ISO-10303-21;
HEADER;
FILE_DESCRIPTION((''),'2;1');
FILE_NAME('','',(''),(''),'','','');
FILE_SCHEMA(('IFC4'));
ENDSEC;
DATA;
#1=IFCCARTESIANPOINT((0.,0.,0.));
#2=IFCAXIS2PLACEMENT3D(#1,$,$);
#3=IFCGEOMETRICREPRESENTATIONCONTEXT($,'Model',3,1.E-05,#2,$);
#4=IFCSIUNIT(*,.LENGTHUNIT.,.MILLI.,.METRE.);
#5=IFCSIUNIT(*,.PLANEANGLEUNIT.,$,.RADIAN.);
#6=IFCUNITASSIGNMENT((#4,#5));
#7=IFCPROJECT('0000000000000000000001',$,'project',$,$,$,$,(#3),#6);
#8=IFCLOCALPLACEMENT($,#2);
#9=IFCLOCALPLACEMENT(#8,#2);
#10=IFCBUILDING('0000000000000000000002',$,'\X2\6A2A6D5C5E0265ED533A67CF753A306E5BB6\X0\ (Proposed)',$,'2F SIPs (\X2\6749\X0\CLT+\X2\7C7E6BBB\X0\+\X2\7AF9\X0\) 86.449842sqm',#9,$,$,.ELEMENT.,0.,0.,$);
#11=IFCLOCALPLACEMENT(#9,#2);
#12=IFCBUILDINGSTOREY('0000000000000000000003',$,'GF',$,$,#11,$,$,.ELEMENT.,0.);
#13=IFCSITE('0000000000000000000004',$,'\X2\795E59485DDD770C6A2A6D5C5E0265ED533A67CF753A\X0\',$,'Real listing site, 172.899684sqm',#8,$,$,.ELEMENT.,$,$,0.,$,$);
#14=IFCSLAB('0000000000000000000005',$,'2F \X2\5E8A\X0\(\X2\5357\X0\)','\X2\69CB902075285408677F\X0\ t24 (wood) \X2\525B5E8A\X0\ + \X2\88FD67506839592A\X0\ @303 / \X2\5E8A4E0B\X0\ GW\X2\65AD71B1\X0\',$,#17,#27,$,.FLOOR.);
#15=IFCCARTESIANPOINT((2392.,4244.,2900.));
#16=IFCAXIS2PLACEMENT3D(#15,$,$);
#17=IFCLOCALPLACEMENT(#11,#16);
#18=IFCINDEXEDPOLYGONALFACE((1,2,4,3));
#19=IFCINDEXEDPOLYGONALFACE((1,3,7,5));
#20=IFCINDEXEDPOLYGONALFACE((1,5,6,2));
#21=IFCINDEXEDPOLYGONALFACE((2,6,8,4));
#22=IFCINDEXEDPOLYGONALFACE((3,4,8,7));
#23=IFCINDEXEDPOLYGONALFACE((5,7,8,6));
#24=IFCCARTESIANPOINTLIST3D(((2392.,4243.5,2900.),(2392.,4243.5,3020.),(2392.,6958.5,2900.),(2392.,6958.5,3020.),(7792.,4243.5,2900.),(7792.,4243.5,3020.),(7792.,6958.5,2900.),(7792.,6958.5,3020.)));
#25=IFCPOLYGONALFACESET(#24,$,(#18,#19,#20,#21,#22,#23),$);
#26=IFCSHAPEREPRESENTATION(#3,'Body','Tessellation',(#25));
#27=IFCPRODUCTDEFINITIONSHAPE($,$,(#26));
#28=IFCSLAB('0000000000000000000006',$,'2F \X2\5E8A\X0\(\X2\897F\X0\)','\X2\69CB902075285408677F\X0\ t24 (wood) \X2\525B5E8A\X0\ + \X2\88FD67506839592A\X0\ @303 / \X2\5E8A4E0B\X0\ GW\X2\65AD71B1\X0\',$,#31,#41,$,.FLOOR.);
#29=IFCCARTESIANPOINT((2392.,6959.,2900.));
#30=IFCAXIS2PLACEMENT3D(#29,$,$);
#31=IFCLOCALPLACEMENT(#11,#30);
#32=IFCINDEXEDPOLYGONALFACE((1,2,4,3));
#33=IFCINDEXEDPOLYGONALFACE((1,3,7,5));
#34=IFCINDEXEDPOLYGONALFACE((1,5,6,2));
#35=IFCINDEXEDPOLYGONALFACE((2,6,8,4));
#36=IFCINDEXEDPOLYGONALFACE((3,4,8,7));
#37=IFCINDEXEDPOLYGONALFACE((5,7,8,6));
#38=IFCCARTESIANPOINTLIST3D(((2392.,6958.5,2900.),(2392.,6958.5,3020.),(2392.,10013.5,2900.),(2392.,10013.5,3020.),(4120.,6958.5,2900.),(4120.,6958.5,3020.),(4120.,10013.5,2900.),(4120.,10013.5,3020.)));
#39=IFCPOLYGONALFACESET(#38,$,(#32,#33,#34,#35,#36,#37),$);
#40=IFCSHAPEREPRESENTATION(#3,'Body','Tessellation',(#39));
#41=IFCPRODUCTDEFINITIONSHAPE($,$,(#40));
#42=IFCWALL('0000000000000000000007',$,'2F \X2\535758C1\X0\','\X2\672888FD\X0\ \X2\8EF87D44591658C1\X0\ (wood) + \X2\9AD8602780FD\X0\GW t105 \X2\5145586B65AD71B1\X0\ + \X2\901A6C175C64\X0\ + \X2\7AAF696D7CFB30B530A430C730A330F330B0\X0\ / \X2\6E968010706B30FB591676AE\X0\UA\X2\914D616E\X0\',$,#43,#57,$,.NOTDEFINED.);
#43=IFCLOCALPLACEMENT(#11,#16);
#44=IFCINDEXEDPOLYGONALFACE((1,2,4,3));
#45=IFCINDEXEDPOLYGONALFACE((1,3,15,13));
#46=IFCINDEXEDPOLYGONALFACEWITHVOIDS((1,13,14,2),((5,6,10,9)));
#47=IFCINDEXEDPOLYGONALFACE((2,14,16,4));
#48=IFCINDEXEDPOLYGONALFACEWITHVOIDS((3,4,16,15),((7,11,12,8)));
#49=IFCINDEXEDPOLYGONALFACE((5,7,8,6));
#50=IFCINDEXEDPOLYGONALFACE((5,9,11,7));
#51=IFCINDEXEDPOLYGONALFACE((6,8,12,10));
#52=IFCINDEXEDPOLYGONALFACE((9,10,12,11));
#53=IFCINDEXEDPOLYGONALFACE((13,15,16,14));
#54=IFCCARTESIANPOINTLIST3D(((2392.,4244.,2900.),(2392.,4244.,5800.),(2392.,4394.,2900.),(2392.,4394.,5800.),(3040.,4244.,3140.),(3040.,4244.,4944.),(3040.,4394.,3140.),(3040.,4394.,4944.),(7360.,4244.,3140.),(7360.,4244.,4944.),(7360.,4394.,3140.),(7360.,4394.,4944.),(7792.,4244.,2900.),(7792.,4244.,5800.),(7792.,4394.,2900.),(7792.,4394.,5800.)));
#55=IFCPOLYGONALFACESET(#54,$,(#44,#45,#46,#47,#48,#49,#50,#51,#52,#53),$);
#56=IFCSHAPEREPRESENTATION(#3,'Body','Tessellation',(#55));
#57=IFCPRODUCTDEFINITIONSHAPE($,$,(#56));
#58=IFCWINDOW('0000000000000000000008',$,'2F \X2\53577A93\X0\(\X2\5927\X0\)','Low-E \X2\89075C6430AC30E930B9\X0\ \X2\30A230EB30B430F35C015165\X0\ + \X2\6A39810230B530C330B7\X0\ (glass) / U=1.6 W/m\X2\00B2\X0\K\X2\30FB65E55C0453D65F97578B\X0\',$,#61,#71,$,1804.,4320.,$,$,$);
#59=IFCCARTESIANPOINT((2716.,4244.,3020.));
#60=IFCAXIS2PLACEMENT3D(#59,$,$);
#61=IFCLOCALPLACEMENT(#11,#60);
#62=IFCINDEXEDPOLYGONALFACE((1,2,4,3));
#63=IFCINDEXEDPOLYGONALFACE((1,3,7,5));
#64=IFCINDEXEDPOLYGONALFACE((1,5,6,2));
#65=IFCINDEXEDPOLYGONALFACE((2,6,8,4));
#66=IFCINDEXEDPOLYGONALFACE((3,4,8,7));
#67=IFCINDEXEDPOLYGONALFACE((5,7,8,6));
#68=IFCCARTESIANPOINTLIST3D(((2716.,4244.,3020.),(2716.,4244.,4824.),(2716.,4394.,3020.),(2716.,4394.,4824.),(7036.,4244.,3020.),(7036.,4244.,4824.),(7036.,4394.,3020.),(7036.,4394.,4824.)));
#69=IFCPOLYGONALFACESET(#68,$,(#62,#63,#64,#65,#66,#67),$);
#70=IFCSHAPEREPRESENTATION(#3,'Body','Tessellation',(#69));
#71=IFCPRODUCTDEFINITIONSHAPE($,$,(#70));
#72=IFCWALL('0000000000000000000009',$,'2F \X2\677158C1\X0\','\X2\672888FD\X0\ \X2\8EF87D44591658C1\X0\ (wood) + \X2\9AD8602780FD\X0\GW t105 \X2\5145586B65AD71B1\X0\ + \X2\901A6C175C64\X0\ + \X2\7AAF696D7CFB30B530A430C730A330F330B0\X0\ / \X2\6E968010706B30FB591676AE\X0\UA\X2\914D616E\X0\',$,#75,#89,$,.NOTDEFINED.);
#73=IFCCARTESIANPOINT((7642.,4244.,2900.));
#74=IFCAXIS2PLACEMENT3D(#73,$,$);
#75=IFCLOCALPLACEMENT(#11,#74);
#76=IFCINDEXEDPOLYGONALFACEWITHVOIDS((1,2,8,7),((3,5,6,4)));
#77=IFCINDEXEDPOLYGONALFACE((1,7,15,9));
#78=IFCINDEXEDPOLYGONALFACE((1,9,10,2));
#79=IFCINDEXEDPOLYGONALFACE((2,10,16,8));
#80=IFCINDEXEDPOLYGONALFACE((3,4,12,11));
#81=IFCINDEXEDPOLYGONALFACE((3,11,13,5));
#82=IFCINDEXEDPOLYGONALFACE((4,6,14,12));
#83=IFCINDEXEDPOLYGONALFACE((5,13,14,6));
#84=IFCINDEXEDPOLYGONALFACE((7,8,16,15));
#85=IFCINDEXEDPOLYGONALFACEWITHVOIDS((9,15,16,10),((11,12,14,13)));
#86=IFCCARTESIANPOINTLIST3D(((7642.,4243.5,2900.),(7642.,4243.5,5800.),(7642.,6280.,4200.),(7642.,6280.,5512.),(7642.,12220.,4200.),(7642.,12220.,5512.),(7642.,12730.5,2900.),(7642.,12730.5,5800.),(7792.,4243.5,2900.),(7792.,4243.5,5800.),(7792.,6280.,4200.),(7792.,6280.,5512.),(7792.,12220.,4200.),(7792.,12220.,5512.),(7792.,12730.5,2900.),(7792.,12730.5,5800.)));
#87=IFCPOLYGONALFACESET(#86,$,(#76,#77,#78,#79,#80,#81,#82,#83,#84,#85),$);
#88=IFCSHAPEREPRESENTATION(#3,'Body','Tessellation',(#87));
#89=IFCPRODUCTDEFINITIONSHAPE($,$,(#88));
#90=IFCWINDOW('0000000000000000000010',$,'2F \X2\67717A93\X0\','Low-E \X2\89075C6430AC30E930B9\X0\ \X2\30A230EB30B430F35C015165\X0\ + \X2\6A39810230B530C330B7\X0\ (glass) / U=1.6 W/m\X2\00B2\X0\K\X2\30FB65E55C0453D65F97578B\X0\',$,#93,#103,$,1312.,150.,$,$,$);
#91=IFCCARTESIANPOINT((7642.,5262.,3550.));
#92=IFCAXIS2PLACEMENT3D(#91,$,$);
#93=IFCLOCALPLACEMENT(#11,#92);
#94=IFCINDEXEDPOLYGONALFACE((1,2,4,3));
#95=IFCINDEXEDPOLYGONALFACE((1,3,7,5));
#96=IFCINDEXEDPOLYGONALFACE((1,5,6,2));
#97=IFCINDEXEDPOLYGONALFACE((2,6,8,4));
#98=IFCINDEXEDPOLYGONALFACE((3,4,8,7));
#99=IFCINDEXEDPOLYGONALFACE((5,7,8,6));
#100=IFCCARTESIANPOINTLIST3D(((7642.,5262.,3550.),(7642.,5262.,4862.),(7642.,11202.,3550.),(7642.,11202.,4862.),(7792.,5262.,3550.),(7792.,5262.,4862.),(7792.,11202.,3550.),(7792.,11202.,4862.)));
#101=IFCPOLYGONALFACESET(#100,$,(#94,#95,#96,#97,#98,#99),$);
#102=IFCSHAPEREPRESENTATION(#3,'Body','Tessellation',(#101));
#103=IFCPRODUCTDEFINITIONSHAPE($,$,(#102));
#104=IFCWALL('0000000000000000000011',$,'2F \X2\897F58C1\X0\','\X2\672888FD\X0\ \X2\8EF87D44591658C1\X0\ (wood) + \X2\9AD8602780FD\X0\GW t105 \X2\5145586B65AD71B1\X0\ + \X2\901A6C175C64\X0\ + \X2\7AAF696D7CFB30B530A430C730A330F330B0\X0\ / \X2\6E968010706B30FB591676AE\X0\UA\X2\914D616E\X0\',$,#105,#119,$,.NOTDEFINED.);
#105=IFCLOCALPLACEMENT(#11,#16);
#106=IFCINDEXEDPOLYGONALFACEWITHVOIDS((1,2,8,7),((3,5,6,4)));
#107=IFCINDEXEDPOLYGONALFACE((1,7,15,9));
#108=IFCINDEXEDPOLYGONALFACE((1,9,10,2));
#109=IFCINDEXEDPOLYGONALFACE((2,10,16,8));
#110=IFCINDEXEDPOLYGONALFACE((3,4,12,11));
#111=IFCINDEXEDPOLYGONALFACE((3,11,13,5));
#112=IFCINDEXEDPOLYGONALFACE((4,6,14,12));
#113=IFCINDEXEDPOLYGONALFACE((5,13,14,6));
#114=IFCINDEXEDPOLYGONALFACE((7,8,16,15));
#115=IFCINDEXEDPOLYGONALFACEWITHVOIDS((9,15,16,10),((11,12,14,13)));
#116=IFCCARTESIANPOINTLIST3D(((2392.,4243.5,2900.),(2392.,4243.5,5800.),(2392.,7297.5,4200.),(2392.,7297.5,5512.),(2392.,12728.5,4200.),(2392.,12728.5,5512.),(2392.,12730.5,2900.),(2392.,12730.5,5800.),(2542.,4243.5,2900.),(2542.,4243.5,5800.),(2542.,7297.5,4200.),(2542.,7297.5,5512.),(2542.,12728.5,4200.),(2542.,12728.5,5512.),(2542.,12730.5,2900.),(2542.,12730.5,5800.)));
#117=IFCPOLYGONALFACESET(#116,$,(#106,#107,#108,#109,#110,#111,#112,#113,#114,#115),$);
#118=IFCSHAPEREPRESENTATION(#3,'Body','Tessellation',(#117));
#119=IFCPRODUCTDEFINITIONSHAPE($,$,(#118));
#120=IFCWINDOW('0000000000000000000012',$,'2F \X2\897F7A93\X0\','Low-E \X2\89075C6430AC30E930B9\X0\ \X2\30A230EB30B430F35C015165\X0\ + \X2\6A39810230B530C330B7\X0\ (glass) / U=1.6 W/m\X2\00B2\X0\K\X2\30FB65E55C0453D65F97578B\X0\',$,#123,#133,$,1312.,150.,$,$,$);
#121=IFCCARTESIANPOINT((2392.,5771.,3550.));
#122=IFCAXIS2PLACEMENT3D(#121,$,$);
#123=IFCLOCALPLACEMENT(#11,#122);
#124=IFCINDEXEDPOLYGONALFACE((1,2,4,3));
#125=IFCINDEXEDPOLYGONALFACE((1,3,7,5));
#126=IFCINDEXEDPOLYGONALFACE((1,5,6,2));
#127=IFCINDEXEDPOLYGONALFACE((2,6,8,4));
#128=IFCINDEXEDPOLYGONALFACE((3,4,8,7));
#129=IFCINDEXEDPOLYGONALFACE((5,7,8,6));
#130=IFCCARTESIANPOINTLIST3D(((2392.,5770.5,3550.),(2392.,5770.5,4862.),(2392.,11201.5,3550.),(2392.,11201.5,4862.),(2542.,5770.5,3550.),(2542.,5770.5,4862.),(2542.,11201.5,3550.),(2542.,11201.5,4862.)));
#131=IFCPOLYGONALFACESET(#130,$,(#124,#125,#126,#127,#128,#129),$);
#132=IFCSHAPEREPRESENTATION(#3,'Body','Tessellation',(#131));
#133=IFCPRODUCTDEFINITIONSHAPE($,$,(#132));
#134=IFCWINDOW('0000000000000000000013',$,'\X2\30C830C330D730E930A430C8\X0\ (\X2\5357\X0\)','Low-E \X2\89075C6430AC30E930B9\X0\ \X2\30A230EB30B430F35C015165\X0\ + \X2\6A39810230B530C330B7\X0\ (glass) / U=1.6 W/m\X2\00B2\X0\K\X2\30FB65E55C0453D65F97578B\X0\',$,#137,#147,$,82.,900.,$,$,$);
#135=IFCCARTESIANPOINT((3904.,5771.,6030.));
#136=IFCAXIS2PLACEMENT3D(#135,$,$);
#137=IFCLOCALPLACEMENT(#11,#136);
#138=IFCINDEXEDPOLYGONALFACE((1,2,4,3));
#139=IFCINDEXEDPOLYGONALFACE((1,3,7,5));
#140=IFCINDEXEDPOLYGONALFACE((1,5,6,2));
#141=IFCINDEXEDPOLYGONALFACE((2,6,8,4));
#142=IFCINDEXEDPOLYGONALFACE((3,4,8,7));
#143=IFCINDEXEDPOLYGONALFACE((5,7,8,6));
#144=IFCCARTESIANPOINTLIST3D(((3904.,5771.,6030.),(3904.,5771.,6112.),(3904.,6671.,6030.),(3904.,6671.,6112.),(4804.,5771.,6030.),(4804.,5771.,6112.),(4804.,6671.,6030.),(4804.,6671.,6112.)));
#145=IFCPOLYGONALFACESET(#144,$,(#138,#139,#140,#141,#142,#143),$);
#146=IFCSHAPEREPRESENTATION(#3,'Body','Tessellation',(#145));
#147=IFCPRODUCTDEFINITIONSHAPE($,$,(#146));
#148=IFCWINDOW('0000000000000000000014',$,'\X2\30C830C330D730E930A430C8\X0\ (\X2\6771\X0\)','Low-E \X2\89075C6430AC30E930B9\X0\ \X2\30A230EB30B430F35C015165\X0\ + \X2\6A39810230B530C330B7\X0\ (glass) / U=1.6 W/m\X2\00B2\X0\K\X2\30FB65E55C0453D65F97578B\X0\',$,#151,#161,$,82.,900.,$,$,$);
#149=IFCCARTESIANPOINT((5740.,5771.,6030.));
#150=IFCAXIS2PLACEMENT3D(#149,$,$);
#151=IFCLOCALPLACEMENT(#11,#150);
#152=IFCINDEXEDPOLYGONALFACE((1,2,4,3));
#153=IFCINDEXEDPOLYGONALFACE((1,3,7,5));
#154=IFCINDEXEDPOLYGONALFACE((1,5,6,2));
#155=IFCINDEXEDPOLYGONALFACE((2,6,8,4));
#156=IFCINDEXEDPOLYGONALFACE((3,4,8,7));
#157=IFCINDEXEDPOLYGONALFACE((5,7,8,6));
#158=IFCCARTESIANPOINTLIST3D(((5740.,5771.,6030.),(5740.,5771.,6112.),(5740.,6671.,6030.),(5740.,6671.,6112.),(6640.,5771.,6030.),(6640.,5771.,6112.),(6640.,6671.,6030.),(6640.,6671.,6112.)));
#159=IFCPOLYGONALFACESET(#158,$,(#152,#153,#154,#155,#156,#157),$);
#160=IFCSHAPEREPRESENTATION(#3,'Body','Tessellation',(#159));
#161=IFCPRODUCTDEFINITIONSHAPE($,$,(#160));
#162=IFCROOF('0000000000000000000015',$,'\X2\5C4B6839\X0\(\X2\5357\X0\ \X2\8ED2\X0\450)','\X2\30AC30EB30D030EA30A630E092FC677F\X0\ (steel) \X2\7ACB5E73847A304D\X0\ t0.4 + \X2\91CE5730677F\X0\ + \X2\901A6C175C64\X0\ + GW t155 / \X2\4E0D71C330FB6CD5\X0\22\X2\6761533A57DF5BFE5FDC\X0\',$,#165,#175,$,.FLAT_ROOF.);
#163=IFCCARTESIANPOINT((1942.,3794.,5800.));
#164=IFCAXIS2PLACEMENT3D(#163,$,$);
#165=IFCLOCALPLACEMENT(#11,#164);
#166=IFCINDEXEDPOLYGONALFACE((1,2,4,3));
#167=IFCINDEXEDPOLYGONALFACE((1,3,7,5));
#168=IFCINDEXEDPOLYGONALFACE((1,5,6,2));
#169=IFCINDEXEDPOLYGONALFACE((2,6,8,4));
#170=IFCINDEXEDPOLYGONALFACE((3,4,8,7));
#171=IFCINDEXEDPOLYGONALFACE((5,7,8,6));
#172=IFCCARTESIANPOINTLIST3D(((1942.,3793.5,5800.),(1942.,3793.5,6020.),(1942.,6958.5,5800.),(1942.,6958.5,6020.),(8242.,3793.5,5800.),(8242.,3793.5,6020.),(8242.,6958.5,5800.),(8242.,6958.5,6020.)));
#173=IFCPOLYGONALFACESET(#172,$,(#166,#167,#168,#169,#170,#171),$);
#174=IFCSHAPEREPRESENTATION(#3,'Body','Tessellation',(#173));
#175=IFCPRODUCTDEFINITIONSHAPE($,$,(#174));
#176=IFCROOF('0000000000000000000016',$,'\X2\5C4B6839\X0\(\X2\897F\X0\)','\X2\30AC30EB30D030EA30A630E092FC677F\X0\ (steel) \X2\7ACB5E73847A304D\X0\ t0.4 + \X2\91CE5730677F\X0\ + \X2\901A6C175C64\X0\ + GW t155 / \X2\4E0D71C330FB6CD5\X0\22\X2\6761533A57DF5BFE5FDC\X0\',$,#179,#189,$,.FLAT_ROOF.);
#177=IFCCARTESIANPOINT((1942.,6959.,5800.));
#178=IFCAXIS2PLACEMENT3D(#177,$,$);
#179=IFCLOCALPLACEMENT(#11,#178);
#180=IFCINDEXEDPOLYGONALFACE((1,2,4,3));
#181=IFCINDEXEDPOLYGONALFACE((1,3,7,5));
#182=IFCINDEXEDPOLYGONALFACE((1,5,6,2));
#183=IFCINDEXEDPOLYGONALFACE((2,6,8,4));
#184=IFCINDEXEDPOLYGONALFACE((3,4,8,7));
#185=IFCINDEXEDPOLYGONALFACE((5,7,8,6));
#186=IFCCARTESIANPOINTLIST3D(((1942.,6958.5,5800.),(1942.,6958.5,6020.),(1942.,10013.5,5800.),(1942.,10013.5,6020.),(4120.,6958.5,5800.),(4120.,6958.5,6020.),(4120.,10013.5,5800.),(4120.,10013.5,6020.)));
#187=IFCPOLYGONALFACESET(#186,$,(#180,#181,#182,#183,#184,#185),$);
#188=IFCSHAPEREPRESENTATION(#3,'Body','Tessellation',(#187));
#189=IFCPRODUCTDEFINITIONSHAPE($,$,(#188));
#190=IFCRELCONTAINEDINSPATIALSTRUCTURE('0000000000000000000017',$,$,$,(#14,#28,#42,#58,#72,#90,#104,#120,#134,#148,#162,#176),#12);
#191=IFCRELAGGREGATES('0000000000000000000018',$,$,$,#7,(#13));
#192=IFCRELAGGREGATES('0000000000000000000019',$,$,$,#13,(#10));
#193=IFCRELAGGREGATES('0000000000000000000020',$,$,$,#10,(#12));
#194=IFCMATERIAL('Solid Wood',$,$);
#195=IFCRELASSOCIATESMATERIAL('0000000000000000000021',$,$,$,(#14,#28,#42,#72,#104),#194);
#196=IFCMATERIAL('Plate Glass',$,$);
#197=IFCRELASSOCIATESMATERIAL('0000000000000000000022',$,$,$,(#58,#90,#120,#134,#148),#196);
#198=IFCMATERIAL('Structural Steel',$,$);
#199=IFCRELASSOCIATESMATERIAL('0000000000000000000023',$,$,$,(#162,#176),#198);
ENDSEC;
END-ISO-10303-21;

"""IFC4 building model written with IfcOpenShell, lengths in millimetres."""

from ifc_helpers import new_model, si_unit, frame, frame_2d, origin, place, context, project, spatial, rectangle, extrude, material, element, fill, save


model = new_model("IFC4")

# Units and contexts
model_context = context("Model", 3, precision=1e-05, world=origin())
ifc_project = project(units=[si_unit("LENGTHUNIT", "METRE", prefix="MILLI"), si_unit("PLANEANGLEUNIT", "RADIAN")], contexts=[model_context])

# Site, building, storey
site_placement = place(None, origin())
site = spatial("IfcSite", under=ifc_project, at=site_placement, Name="神奈川県横浜市旭区柏町", ObjectType="Real listing site, 172.899684sqm", CompositionType="ELEMENT", RefElevation=0.0)
building_placement = place(site_placement, origin())
building = spatial("IfcBuilding", under=site, at=building_placement, Name="横浜市旭区柏町の家 (Proposed)", ObjectType="2F SIPs (杉CLT+籾殻+竹) 86.449842sqm", CompositionType="ELEMENT", ElevationOfRefHeight=0.0, ElevationOfTerrain=0.0)
storey_placement = place(building_placement, origin())
storey = spatial("IfcBuildingStorey", under=building, at=storey_placement, Name="GF", CompositionType="ELEMENT", Elevation=0.0)

# Slabs
ifc_material_1 = material(Name="Solid Wood")
slab_1_placement = place(storey_placement, frame((2392.0, 4244.0, 2900.0)))
element("IfcSlab", 1, at=slab_1_placement, inside=storey, material=ifc_material_1, Name="2F 床(南)", Description="構造用合板 t24 (wood) 剛床 + 製材根太 @303 / 床下 GW断熱", PredefinedType="FLOOR", context=model_context, shape_type="SweptSolid", body=[
    extrude(rectangle(XDim=5400.0, YDim=2715.0, at=frame_2d((2700.0, 1357.0))), frame((2392.0, 4244.0, 2900.0)), (0.0, 0.0, 1.0), 120.0),
])
slab_2_placement = place(storey_placement, frame((2392.0, 6959.0, 2900.0)))
element("IfcSlab", 2, at=slab_2_placement, inside=storey, material=ifc_material_1, Name="2F 床(西)", Description="構造用合板 t24 (wood) 剛床 + 製材根太 @303 / 床下 GW断熱", PredefinedType="FLOOR", context=model_context, shape_type="SweptSolid", body=[
    extrude(rectangle(XDim=1728.0, YDim=3055.0, at=frame_2d((864.0, 1527.0))), frame((2392.0, 6959.0, 2900.0)), (0.0, 0.0, 1.0), 120.0),
])

# Walls, openings, windows
wall_1_placement = place(storey_placement, frame((2392.0, 4244.0, 2900.0)))
wall_1 = element("IfcWall", 3, at=wall_1_placement, inside=storey, material=ifc_material_1, Name="2F 南壁", Description="木製 軸組外壁 (wood) + 高性能GW t105 充填断熱 + 通気層 + 窯業系サイディング / 準耐火・外皮UA配慮", PredefinedType="NOTDEFINED", context=model_context, shape_type="SweptSolid", body=[
    extrude(rectangle(XDim=5400.0, YDim=150.0, at=frame_2d((2700.0, 75.0))), frame((2392.0, 4244.0, 2900.0)), (0.0, 0.0, 1.0), 2900.0),
])
opening_1_placement = place(storey_placement, frame((2716.0, 4244.0, 3020.0)))
opening_1 = element("IfcOpeningElement", 4, at=opening_1_placement, cuts=wall_1, PredefinedType="NOTDEFINED", context=model_context, shape_type="SweptSolid", body=[
    extrude(rectangle(XDim=4320.0, YDim=150.0, at=frame_2d((2160.0, 75.0))), frame((2716.0, 4244.0, 3020.0)), (0.0, 0.0, 1.0), 1804.0),
])
ifc_material_2 = material(Name="Plate Glass")
window_1_placement = place(storey_placement, frame((2716.0, 4244.0, 3020.0)))
window_1 = element("IfcWindow", 5, at=window_1_placement, inside=storey, material=ifc_material_2, Name="2F 南窓(大)", Description="Low-E 複層ガラス アルゴン封入 + 樹脂サッシ (glass) / U=1.6 W/m²K・日射取得型", OverallHeight=1804.0, OverallWidth=4320.0, context=model_context, shape_type="SweptSolid", body=[
    extrude(rectangle(XDim=4320.0, YDim=150.0, at=frame_2d((2160.0, 75.0))), frame((2716.0, 4244.0, 3020.0)), (0.0, 0.0, 1.0), 1804.0),
])
fill(opening_1, window_1)
wall_2_placement = place(storey_placement, frame((7642.0, 4244.0, 2900.0)))
wall_2 = element("IfcWall", 6, at=wall_2_placement, inside=storey, material=ifc_material_1, Name="2F 東壁", Description="木製 軸組外壁 (wood) + 高性能GW t105 充填断熱 + 通気層 + 窯業系サイディング / 準耐火・外皮UA配慮", PredefinedType="NOTDEFINED", context=model_context, shape_type="SweptSolid", body=[
    extrude(rectangle(XDim=150.0, YDim=8487.0, at=frame_2d((75.0, 4243.0))), frame((7642.0, 4244.0, 2900.0)), (0.0, 0.0, 1.0), 2900.0),
])
opening_2_placement = place(storey_placement, frame((7642.0, 5262.0, 3550.0)))
opening_2 = element("IfcOpeningElement", 7, at=opening_2_placement, cuts=wall_2, PredefinedType="NOTDEFINED", context=model_context, shape_type="SweptSolid", body=[
    extrude(rectangle(XDim=150.0, YDim=5940.0, at=frame_2d((75.0, 2970.0))), frame((7642.0, 5262.0, 3550.0)), (0.0, 0.0, 1.0), 1312.0),
])
window_2_placement = place(storey_placement, frame((7642.0, 5262.0, 3550.0)))
window_2 = element("IfcWindow", 8, at=window_2_placement, inside=storey, material=ifc_material_2, Name="2F 東窓", Description="Low-E 複層ガラス アルゴン封入 + 樹脂サッシ (glass) / U=1.6 W/m²K・日射取得型", OverallHeight=1312.0, OverallWidth=150.0, context=model_context, shape_type="SweptSolid", body=[
    extrude(rectangle(XDim=150.0, YDim=5940.0, at=frame_2d((75.0, 2970.0))), frame((7642.0, 5262.0, 3550.0)), (0.0, 0.0, 1.0), 1312.0),
])
fill(opening_2, window_2)
wall_3_placement = place(storey_placement, frame((2392.0, 4244.0, 2900.0)))
wall_3 = element("IfcWall", 9, at=wall_3_placement, inside=storey, material=ifc_material_1, Name="2F 西壁", Description="木製 軸組外壁 (wood) + 高性能GW t105 充填断熱 + 通気層 + 窯業系サイディング / 準耐火・外皮UA配慮", PredefinedType="NOTDEFINED", context=model_context, shape_type="SweptSolid", body=[
    extrude(rectangle(XDim=150.0, YDim=8487.0, at=frame_2d((75.0, 4243.0))), frame((2392.0, 4244.0, 2900.0)), (0.0, 0.0, 1.0), 2900.0),
])
opening_3_placement = place(storey_placement, frame((2392.0, 5771.0, 3550.0)))
opening_3 = element("IfcOpeningElement", 10, at=opening_3_placement, cuts=wall_3, PredefinedType="NOTDEFINED", context=model_context, shape_type="SweptSolid", body=[
    extrude(rectangle(XDim=150.0, YDim=5431.0, at=frame_2d((75.0, 2715.0))), frame((2392.0, 5771.0, 3550.0)), (0.0, 0.0, 1.0), 1312.0),
])
window_3_placement = place(storey_placement, frame((2392.0, 5771.0, 3550.0)))
window_3 = element("IfcWindow", 11, at=window_3_placement, inside=storey, material=ifc_material_2, Name="2F 西窓", Description="Low-E 複層ガラス アルゴン封入 + 樹脂サッシ (glass) / U=1.6 W/m²K・日射取得型", OverallHeight=1312.0, OverallWidth=150.0, context=model_context, shape_type="SweptSolid", body=[
    extrude(rectangle(XDim=150.0, YDim=5431.0, at=frame_2d((75.0, 2715.0))), frame((2392.0, 5771.0, 3550.0)), (0.0, 0.0, 1.0), 1312.0),
])
fill(opening_3, window_3)

# Windows
window_4_placement = place(storey_placement, frame((3904.0, 5771.0, 6030.0)))
element("IfcWindow", 12, at=window_4_placement, inside=storey, material=ifc_material_2, Name="トップライト (南)", Description="Low-E 複層ガラス アルゴン封入 + 樹脂サッシ (glass) / U=1.6 W/m²K・日射取得型", OverallHeight=82.0, OverallWidth=900.0, context=model_context, shape_type="SweptSolid", body=[
    extrude(rectangle(XDim=900.0, YDim=900.0, at=frame_2d((450.0, 450.0))), frame((3904.0, 5771.0, 6030.0)), (0.0, 0.0, 1.0), 82.0),
])
window_5_placement = place(storey_placement, frame((5740.0, 5771.0, 6030.0)))
element("IfcWindow", 13, at=window_5_placement, inside=storey, material=ifc_material_2, Name="トップライト (東)", Description="Low-E 複層ガラス アルゴン封入 + 樹脂サッシ (glass) / U=1.6 W/m²K・日射取得型", OverallHeight=82.0, OverallWidth=900.0, context=model_context, shape_type="SweptSolid", body=[
    extrude(rectangle(XDim=900.0, YDim=900.0, at=frame_2d((450.0, 450.0))), frame((5740.0, 5771.0, 6030.0)), (0.0, 0.0, 1.0), 82.0),
])

# Roofs
ifc_material_3 = material(Name="Structural Steel")
roof_1_placement = place(storey_placement, frame((1942.0, 3794.0, 5800.0)))
element("IfcRoof", 14, at=roof_1_placement, inside=storey, material=ifc_material_3, Name="屋根(南 軒450)", Description="ガルバリウム鋼板 (steel) 立平葺き t0.4 + 野地板 + 通気層 + GW t155 / 不燃・法22条区域対応", PredefinedType="FLAT_ROOF", context=model_context, shape_type="SweptSolid", body=[
    extrude(rectangle(XDim=6300.0, YDim=3165.0, at=frame_2d((3150.0, 1582.0))), frame((1942.0, 3794.0, 5800.0)), (0.0, 0.0, 1.0), 220.0),
])
roof_2_placement = place(storey_placement, frame((1942.0, 6959.0, 5800.0)))
element("IfcRoof", 15, at=roof_2_placement, inside=storey, material=ifc_material_3, Name="屋根(西)", Description="ガルバリウム鋼板 (steel) 立平葺き t0.4 + 野地板 + 通気層 + GW t155 / 不燃・法22条区域対応", PredefinedType="FLAT_ROOF", context=model_context, shape_type="SweptSolid", body=[
    extrude(rectangle(XDim=2178.0, YDim=3055.0, at=frame_2d((1089.0, 1527.0))), frame((1942.0, 6959.0, 5800.0)), (0.0, 0.0, 1.0), 220.0),
])

save(model, "model.ifc")
